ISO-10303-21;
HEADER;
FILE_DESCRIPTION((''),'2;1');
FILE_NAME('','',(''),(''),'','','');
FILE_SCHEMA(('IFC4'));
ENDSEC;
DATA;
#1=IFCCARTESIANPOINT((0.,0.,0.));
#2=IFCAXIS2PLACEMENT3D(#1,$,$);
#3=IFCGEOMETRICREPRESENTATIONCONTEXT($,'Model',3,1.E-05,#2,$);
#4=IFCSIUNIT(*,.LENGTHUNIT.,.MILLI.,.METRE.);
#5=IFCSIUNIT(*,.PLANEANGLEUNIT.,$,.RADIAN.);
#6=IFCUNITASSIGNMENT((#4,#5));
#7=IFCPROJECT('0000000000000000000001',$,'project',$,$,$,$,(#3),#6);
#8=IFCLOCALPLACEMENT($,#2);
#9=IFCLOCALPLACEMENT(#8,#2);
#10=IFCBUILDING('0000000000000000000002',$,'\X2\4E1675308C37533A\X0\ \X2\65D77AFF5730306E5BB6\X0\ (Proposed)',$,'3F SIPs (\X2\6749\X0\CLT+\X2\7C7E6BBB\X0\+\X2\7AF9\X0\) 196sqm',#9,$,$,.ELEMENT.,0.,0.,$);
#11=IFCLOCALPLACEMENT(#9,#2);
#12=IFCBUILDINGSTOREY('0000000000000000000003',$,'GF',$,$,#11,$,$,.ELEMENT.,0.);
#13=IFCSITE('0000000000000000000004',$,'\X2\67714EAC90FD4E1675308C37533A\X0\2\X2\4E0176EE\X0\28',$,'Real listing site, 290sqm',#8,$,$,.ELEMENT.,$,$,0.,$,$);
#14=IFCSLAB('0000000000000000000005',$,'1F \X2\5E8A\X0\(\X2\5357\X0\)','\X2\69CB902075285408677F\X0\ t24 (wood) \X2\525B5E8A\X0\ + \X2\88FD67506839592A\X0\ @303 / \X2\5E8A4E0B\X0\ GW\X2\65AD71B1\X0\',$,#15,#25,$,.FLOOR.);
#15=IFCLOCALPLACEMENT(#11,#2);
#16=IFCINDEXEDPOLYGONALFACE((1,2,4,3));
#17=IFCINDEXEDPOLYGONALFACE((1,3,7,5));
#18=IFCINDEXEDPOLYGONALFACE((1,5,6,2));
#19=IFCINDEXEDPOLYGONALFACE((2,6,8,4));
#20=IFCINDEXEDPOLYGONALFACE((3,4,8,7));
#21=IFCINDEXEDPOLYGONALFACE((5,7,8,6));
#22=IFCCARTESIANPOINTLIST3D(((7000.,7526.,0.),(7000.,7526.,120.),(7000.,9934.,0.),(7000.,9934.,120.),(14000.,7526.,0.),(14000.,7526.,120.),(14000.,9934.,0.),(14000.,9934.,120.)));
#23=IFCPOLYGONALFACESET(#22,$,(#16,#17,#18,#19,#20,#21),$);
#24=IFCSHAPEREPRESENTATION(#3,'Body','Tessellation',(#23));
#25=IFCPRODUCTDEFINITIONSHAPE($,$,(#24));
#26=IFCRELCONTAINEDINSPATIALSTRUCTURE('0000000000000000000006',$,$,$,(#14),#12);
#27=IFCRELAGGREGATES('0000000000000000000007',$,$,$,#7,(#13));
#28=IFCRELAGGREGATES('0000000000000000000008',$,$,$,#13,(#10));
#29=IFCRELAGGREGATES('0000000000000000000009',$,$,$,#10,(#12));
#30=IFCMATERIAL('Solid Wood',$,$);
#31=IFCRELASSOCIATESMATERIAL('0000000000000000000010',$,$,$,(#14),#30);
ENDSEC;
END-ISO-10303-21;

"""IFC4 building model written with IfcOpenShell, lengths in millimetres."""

from ifc_helpers import new_model, si_unit, frame, frame_2d, origin, place, context, project, spatial, rectangle, extrude, material, element, save


model = new_model("IFC4")

# Units and contexts
model_context = context("Model", 3, precision=1e-05, world=origin())
ifc_project = project(units=[si_unit("LENGTHUNIT", "METRE", prefix="MILLI"), si_unit("PLANEANGLEUNIT", "RADIAN")], contexts=[model_context])

# Site, building, storey
site_placement = place(None, origin())
site = spatial("IfcSite", under=ifc_project, at=site_placement, Name="東京都世田谷区2丁目28", ObjectType="Real listing site, 290sqm", CompositionType="ELEMENT", RefElevation=0.0)
building_placement = place(site_placement, origin())
building = spatial("IfcBuilding", under=site, at=building_placement, Name="世田谷区 旗竿地の家 (Proposed)", ObjectType="3F SIPs (杉CLT+籾殻+竹) 196sqm", CompositionType="ELEMENT", ElevationOfRefHeight=0.0, ElevationOfTerrain=0.0)
storey_placement = place(building_placement, origin())
storey = spatial("IfcBuildingStorey", under=building, at=storey_placement, Name="GF", CompositionType="ELEMENT", Elevation=0.0)

# Slab
ifc_material_1 = material(Name="Solid Wood")
slab_1_placement = place(storey_placement, frame((3500.0, 3763.0, 0.0)))
element("IfcSlab", 1, at=slab_1_placement, inside=storey, material=ifc_material_1, Name="1F 床(南)", Description="構造用合板 t24 (wood) 剛床 + 製材根太 @303 / 床下 GW断熱", PredefinedType="FLOOR", context=model_context, shape_type="SweptSolid", body=[
    extrude(rectangle(XDim=7000.0, YDim=2408.0, at=frame_2d((3500.0, 1204.0))), frame((3500.0, 3763.0, 0.0)), (0.0, 0.0, 1.0), 120.0),
])

save(model, "model.ifc")
